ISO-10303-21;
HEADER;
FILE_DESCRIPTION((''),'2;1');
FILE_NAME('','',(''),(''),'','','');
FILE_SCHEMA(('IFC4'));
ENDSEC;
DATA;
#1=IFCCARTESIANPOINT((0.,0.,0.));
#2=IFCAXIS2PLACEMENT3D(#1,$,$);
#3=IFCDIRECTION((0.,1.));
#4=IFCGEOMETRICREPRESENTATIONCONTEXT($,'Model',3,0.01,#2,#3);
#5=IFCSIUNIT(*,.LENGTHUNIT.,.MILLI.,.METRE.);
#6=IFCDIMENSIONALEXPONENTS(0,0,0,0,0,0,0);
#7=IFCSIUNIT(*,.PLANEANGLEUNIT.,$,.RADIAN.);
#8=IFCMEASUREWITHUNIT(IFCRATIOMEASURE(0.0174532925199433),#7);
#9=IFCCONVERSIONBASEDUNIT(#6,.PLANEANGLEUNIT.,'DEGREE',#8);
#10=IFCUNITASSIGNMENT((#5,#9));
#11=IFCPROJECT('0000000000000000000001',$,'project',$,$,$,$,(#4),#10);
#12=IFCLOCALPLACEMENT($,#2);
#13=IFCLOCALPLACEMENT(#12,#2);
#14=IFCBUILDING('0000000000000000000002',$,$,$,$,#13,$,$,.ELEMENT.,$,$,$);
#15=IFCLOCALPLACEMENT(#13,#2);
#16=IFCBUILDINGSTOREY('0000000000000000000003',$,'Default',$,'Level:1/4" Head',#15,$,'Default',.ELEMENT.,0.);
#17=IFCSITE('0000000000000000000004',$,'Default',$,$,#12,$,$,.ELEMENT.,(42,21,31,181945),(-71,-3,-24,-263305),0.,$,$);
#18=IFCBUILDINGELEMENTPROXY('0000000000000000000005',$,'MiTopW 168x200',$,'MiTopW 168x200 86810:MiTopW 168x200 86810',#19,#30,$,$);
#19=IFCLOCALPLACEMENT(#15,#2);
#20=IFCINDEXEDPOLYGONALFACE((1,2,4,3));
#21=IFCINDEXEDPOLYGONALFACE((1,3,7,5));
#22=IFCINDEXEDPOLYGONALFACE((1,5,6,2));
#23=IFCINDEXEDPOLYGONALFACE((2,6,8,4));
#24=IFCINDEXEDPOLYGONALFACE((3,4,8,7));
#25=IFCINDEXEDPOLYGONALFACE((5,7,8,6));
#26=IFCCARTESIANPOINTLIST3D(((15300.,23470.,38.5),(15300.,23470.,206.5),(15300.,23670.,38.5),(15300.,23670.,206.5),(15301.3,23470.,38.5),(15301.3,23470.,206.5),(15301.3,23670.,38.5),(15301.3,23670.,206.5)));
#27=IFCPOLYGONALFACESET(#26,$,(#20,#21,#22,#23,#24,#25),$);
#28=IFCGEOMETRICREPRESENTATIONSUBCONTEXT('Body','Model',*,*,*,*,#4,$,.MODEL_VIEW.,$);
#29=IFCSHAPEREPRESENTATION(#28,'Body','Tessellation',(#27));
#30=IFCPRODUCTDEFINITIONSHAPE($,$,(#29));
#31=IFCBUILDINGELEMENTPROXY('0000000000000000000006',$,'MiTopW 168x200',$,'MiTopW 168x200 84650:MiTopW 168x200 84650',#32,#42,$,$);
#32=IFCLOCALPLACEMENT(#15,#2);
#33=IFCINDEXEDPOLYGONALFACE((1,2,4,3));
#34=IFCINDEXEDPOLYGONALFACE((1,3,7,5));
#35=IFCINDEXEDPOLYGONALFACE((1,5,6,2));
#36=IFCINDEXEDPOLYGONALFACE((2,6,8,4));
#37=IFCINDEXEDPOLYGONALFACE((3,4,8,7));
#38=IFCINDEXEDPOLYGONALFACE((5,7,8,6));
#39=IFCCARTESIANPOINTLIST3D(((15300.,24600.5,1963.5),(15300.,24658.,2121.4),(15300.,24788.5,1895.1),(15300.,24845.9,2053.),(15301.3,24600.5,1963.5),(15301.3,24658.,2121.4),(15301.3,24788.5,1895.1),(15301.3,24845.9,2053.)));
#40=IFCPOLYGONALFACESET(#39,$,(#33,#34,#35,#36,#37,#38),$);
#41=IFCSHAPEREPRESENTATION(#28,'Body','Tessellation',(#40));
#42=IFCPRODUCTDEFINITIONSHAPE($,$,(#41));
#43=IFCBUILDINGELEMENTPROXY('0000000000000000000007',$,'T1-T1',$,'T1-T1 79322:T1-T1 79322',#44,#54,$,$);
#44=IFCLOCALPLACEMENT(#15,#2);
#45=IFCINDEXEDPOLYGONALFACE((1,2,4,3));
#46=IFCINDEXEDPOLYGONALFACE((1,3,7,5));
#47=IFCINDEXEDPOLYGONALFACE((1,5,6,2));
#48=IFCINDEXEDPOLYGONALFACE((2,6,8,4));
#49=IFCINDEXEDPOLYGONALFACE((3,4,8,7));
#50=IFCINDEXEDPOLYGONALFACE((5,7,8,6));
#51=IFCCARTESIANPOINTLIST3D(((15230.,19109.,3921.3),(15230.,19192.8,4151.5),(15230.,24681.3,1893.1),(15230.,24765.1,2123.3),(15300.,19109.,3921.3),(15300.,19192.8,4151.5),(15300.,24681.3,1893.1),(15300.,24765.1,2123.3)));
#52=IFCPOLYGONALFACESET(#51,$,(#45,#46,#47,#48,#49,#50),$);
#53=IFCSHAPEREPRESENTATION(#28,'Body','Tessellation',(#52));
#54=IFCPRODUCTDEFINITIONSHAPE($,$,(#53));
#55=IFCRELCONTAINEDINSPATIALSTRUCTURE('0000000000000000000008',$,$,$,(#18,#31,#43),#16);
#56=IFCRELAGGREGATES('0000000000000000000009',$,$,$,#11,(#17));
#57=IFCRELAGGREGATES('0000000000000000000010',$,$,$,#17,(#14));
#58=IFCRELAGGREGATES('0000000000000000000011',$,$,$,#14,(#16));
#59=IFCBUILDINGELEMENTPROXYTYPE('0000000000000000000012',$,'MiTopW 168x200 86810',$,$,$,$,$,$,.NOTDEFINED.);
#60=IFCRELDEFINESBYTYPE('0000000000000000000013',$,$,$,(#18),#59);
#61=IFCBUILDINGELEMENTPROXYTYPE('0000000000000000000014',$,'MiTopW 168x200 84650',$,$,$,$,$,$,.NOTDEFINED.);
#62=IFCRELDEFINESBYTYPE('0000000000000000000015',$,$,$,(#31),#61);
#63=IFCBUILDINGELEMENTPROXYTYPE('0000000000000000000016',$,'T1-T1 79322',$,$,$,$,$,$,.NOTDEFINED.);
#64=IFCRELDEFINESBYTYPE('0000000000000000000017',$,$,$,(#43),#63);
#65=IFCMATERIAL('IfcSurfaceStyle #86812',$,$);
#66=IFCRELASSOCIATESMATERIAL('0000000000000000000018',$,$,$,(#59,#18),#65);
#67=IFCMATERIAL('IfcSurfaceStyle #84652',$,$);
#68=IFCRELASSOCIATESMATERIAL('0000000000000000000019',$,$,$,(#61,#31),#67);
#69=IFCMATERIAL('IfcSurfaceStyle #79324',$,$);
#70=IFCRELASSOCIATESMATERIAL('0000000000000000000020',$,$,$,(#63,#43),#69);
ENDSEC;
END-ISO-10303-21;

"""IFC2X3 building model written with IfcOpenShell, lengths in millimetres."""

from ifc_helpers import new_model, entity, si_unit, converted_unit, direction, frame, origin, origin_2d_with_axis, place, context, subcontext, project, spatial, polyline, rectangle, outline, extrude, source, transform, mapped, material, type_object, type_shapes, element, save


model = new_model("IFC2X3")

# Units and contexts
model_context = context("Model", 3, precision=0.01, world=origin(), true_north=direction((0.0, 1.0)))
body_context = subcontext(model_context, "Body", "Model", "MODEL_VIEW")
ifc_project = project(units=[si_unit("LENGTHUNIT", "METRE", prefix="MILLI"), converted_unit("PLANEANGLEUNIT", "DEGREE", entity("IfcRatioMeasure", 0.0174532925199433), si_unit("PLANEANGLEUNIT", "RADIAN"), dimensions=[0, 0, 0, 0, 0, 0, 0])], contexts=[model_context])

# Site, building, storey
site_placement = place(None, origin())
site = spatial("IfcSite", under=ifc_project, at=site_placement, Name="Default", CompositionType="ELEMENT", RefLatitude=(42, 21, 31, 181945), RefLongitude=(-71, -3, -24, -263305), RefElevation=0.0)
building_placement = place(site_placement, origin())
building = spatial("IfcBuilding", under=site, at=building_placement, CompositionType="ELEMENT")
storey_placement = place(building_placement, origin())
storey = spatial("IfcBuildingStorey", under=building, at=storey_placement, Name="Default", ObjectType="Level:1/4\" Head", LongName="Default", CompositionType="ELEMENT", Elevation=0.0)

# Building element proxies
ifc_material_1 = material(Name="IfcSurfaceStyle #86812")
building_element_proxy_type_1 = type_object("IfcBuildingElementProxyType", Name="MiTopW 168x200 86810", PredefinedType="NOTDEFINED", material=ifc_material_1)
shared_shape_1 = source(origin(), body_context, "Body", "SweptSolid", [
    extrude(rectangle(XDim=200.0, YDim=168.0, at=origin_2d_with_axis()), frame((100.0, 84.0, 0.0), z_axis=(0.0, 0.0, 1.0), x_axis=(-1.0, 0.0, 0.0)), (0.0, 0.0, 1.0), 1.3),
])
type_shapes(building_element_proxy_type_1, [shared_shape_1])
proxy_1_placement = place(building_placement, frame((15301.3, 23470.0, 206.5), z_axis=(-1.0, 0.0, 0.0), x_axis=(0.0, 1.0, 0.0)))
element("IfcBuildingElementProxy", 1, at=proxy_1_placement, inside=storey, type_object=building_element_proxy_type_1, material=ifc_material_1, Name="MiTopW 168x200", ObjectType="MiTopW 168x200 86810:MiTopW 168x200 86810", context=body_context, shape_type="MappedRepresentation", body=[
    mapped(shared_shape_1, transform((0.0, 0.0, 0.0), scale=1.0)),
])
ifc_material_2 = material(Name="IfcSurfaceStyle #84652")
building_element_proxy_type_2 = type_object("IfcBuildingElementProxyType", Name="MiTopW 168x200 84650", PredefinedType="NOTDEFINED", material=ifc_material_2)
shared_shape_2 = source(origin(), body_context, "Body", "SweptSolid", [
    extrude(outline(polyline([(-100.0, -84.0), (100.0, -84.0), (100.0, 84.0), (-100.0, 84.0), (-100.0, -84.0)])), frame((100.0, 84.0, 0.0), z_axis=(0.0, 0.0, 1.0), x_axis=(-1.0, 0.0, 0.0)), (0.0, 0.0, 1.0), 1.3),
])
type_shapes(building_element_proxy_type_2, [shared_shape_2])
proxy_2_placement = place(building_placement, frame((15301.3, 24788.5, 1895.1), z_axis=(-1.0, 0.0, 0.0), x_axis=(0.0, -0.939693, 0.34202)))
element("IfcBuildingElementProxy", 2, at=proxy_2_placement, inside=storey, type_object=building_element_proxy_type_2, material=ifc_material_2, Name="MiTopW 168x200", ObjectType="MiTopW 168x200 84650:MiTopW 168x200 84650", context=body_context, shape_type="MappedRepresentation", body=[
    mapped(shared_shape_2, transform((0.0, 0.0, 0.0), scale=1.0)),
])
ifc_material_3 = material(Name="IfcSurfaceStyle #79324")
building_element_proxy_type_3 = type_object("IfcBuildingElementProxyType", Name="T1-T1 79322", PredefinedType="NOTDEFINED", material=ifc_material_3)
shared_shape_3 = source(origin(), body_context, "Body", "SweptSolid", [
    extrude(outline(polyline([(-2965.0, -122.5), (2965.0, -122.5), (2965.0, 122.5), (-2965.0, 122.5), (-2965.0, -122.5)])), frame((2965.0, 122.5, 0.0), z_axis=(0.0, 0.0, 1.0), x_axis=(-1.0, 0.0, 0.0)), (0.0, 0.0, 1.0), 70.0),
])
type_shapes(building_element_proxy_type_3, [shared_shape_3])
proxy_3_placement = place(building_placement, frame((15300.0, 24681.3, 1893.1), z_axis=(-1.0, 0.0, 0.0), x_axis=(0.0, -0.939693, 0.34202)))
element("IfcBuildingElementProxy", 3, at=proxy_3_placement, inside=storey, type_object=building_element_proxy_type_3, material=ifc_material_3, Name="T1-T1", ObjectType="T1-T1 79322:T1-T1 79322", context=body_context, shape_type="MappedRepresentation", body=[
    mapped(shared_shape_3, transform((0.0, 0.0, 0.0), scale=1.0)),
])

save(model, "model.ifc")
